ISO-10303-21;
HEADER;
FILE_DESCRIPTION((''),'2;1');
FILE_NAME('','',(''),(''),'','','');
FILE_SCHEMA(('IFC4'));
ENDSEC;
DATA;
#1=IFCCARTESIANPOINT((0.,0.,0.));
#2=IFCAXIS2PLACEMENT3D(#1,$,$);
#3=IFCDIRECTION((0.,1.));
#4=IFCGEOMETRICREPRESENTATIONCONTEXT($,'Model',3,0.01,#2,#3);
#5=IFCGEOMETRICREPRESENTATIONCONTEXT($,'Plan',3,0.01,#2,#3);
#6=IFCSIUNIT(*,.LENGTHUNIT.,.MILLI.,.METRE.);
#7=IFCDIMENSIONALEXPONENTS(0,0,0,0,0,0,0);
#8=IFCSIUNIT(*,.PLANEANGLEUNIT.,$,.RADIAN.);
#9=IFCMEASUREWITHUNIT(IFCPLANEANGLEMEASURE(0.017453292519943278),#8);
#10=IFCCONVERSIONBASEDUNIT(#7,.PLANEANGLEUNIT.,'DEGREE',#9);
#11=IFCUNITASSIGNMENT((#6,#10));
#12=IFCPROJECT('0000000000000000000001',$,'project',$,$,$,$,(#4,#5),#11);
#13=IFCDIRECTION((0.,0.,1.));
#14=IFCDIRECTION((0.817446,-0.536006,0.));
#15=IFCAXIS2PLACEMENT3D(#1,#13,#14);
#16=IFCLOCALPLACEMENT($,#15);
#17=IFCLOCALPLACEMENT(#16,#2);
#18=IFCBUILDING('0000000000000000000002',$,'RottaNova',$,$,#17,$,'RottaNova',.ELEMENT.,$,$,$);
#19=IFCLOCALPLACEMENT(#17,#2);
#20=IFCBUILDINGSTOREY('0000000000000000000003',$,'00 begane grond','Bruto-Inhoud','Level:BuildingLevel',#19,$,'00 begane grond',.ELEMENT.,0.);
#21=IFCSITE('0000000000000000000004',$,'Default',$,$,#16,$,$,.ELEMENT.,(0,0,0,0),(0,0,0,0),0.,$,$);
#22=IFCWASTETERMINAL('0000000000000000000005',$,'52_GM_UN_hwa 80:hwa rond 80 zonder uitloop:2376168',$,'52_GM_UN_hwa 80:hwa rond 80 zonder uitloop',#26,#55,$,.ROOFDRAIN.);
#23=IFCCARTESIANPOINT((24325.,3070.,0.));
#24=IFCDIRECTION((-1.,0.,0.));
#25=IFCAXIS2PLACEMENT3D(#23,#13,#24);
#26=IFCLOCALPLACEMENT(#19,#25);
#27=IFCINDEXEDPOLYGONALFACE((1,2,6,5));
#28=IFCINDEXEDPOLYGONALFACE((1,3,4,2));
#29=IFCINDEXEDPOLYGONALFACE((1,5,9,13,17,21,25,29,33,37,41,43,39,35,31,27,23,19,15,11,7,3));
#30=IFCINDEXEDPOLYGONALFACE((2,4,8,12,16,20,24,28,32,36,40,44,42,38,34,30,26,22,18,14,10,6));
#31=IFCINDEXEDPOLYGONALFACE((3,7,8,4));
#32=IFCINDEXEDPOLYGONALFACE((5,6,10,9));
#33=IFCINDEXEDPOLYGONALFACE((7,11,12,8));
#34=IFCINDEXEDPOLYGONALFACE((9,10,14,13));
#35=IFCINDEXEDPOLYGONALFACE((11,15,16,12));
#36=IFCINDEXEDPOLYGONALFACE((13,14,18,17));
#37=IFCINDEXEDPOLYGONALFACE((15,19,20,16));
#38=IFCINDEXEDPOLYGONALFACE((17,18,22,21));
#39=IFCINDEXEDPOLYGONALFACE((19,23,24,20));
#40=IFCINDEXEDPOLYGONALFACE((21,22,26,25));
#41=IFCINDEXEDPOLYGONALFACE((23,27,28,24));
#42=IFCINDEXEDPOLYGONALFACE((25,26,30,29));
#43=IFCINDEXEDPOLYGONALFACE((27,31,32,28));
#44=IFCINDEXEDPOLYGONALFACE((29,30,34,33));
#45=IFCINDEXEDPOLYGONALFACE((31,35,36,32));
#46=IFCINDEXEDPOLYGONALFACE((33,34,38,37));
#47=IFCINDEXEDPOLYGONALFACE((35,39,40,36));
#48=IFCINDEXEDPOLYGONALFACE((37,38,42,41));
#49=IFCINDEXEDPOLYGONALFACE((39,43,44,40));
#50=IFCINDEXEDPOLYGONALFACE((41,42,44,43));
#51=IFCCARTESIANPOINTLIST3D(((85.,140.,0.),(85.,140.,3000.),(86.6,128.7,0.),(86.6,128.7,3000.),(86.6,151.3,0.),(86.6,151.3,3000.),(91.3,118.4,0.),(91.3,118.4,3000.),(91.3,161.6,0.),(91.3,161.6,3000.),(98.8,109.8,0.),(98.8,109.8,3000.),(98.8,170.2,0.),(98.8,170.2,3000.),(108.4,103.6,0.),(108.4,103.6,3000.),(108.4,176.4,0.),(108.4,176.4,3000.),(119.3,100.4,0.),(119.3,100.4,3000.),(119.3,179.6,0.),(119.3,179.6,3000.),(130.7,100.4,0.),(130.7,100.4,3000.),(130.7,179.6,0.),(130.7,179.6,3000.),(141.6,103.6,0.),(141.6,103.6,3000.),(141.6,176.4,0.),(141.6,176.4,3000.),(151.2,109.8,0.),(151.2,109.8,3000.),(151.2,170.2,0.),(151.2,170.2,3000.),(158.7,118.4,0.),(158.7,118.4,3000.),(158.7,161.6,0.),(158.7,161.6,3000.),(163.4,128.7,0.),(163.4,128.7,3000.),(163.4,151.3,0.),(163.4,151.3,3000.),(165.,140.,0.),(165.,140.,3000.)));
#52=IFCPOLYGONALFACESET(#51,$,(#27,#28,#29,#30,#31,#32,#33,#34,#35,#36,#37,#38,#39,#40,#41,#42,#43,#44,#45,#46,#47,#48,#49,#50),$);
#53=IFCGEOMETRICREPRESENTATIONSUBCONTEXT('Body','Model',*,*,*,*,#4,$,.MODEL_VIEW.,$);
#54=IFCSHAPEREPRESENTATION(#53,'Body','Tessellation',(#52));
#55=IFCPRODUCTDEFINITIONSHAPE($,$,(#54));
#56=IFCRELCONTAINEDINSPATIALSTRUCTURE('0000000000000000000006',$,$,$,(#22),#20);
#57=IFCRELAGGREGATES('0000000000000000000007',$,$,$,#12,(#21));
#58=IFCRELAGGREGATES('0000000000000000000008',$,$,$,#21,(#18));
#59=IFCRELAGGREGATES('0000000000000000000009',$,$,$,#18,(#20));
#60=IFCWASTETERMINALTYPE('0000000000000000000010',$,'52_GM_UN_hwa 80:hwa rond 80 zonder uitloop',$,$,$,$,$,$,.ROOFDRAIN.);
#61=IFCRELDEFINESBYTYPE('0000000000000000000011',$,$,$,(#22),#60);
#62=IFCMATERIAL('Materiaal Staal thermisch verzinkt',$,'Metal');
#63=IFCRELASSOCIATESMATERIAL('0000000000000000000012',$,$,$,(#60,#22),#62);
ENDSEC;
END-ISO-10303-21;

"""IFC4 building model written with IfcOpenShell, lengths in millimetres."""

from ifc_helpers import new_model, entity, si_unit, converted_unit, direction, frame, origin, place, context, subcontext, project, spatial, arc, indexed_curve, outline, extrude, source, transform, mapped, material, type_object, type_shapes, element, save


model = new_model("IFC4")

# Units and contexts
model_context = context("Model", 3, precision=0.01, world=origin(), true_north=direction((0.0, 1.0)))
plan_context = context("Plan", 3, precision=0.01, world=origin(), true_north=direction((0.0, 1.0)))
body_context = subcontext(model_context, "Body", "Model", "MODEL_VIEW")
ifc_project = project(units=[si_unit("LENGTHUNIT", "METRE", prefix="MILLI"), converted_unit("PLANEANGLEUNIT", "DEGREE", entity("IfcPlaneAngleMeasure", 0.017453292519943278), si_unit("PLANEANGLEUNIT", "RADIAN"), dimensions=[0, 0, 0, 0, 0, 0, 0])], contexts=[model_context, plan_context])

# Site, building, storey
site_placement = place(None, frame((0.0, 0.0, 0.0), z_axis=(0.0, 0.0, 1.0), x_axis=(0.817446, -0.536006, 0.0)))
site = spatial("IfcSite", under=ifc_project, at=site_placement, Name="Default", CompositionType="ELEMENT", RefLatitude=(0, 0, 0, 0), RefLongitude=(0, 0, 0, 0), RefElevation=0.0)
building_placement = place(site_placement, origin())
building = spatial("IfcBuilding", under=site, at=building_placement, Name="RottaNova", LongName="RottaNova", CompositionType="ELEMENT")
storey_placement = place(building_placement, origin())
storey = spatial("IfcBuildingStorey", under=building, at=storey_placement, Name="00 begane grond", Description="Bruto-Inhoud", ObjectType="Level:BuildingLevel", LongName="00 begane grond", CompositionType="ELEMENT", Elevation=0.0)

# Waste terminal
ifc_material_1 = material(Name="Materiaal Staal thermisch verzinkt", Category="Metal")
waste_terminal_type = type_object("IfcWasteTerminalType", Name="52_GM_UN_hwa 80:hwa rond 80 zonder uitloop", PredefinedType="ROOFDRAIN", material=ifc_material_1)
shared_shape_1 = source(origin(), body_context, "Body", "SweptSolid", [
    extrude(outline(indexed_curve([(-40.0, 0.0), (0.0, -40.0), (40.0, 0.0), (0.0, 40.0)], segments=[arc(1, 2, 3), arc(3, 4, 1)], self_intersect=False)), frame((125.0, 140.0, 0.0)), (0.0, 0.0, 1.0), 3000.0),
])
type_shapes(waste_terminal_type, [shared_shape_1])
waste_terminal_placement = place(storey_placement, frame((24325.0, 3070.0, 0.0), z_axis=(0.0, 0.0, 1.0), x_axis=(-1.0, 0.0, 0.0)))
element("IfcWasteTerminal", 1, at=waste_terminal_placement, inside=storey, type_object=waste_terminal_type, material=ifc_material_1, Name="52_GM_UN_hwa 80:hwa rond 80 zonder uitloop:2376168", ObjectType="52_GM_UN_hwa 80:hwa rond 80 zonder uitloop", PredefinedType="ROOFDRAIN", context=body_context, shape_type="MappedRepresentation", body=[
    mapped(shared_shape_1, transform((0.0, 0.0, 0.0), scale=1.0)),
])

save(model, "model.ifc")
